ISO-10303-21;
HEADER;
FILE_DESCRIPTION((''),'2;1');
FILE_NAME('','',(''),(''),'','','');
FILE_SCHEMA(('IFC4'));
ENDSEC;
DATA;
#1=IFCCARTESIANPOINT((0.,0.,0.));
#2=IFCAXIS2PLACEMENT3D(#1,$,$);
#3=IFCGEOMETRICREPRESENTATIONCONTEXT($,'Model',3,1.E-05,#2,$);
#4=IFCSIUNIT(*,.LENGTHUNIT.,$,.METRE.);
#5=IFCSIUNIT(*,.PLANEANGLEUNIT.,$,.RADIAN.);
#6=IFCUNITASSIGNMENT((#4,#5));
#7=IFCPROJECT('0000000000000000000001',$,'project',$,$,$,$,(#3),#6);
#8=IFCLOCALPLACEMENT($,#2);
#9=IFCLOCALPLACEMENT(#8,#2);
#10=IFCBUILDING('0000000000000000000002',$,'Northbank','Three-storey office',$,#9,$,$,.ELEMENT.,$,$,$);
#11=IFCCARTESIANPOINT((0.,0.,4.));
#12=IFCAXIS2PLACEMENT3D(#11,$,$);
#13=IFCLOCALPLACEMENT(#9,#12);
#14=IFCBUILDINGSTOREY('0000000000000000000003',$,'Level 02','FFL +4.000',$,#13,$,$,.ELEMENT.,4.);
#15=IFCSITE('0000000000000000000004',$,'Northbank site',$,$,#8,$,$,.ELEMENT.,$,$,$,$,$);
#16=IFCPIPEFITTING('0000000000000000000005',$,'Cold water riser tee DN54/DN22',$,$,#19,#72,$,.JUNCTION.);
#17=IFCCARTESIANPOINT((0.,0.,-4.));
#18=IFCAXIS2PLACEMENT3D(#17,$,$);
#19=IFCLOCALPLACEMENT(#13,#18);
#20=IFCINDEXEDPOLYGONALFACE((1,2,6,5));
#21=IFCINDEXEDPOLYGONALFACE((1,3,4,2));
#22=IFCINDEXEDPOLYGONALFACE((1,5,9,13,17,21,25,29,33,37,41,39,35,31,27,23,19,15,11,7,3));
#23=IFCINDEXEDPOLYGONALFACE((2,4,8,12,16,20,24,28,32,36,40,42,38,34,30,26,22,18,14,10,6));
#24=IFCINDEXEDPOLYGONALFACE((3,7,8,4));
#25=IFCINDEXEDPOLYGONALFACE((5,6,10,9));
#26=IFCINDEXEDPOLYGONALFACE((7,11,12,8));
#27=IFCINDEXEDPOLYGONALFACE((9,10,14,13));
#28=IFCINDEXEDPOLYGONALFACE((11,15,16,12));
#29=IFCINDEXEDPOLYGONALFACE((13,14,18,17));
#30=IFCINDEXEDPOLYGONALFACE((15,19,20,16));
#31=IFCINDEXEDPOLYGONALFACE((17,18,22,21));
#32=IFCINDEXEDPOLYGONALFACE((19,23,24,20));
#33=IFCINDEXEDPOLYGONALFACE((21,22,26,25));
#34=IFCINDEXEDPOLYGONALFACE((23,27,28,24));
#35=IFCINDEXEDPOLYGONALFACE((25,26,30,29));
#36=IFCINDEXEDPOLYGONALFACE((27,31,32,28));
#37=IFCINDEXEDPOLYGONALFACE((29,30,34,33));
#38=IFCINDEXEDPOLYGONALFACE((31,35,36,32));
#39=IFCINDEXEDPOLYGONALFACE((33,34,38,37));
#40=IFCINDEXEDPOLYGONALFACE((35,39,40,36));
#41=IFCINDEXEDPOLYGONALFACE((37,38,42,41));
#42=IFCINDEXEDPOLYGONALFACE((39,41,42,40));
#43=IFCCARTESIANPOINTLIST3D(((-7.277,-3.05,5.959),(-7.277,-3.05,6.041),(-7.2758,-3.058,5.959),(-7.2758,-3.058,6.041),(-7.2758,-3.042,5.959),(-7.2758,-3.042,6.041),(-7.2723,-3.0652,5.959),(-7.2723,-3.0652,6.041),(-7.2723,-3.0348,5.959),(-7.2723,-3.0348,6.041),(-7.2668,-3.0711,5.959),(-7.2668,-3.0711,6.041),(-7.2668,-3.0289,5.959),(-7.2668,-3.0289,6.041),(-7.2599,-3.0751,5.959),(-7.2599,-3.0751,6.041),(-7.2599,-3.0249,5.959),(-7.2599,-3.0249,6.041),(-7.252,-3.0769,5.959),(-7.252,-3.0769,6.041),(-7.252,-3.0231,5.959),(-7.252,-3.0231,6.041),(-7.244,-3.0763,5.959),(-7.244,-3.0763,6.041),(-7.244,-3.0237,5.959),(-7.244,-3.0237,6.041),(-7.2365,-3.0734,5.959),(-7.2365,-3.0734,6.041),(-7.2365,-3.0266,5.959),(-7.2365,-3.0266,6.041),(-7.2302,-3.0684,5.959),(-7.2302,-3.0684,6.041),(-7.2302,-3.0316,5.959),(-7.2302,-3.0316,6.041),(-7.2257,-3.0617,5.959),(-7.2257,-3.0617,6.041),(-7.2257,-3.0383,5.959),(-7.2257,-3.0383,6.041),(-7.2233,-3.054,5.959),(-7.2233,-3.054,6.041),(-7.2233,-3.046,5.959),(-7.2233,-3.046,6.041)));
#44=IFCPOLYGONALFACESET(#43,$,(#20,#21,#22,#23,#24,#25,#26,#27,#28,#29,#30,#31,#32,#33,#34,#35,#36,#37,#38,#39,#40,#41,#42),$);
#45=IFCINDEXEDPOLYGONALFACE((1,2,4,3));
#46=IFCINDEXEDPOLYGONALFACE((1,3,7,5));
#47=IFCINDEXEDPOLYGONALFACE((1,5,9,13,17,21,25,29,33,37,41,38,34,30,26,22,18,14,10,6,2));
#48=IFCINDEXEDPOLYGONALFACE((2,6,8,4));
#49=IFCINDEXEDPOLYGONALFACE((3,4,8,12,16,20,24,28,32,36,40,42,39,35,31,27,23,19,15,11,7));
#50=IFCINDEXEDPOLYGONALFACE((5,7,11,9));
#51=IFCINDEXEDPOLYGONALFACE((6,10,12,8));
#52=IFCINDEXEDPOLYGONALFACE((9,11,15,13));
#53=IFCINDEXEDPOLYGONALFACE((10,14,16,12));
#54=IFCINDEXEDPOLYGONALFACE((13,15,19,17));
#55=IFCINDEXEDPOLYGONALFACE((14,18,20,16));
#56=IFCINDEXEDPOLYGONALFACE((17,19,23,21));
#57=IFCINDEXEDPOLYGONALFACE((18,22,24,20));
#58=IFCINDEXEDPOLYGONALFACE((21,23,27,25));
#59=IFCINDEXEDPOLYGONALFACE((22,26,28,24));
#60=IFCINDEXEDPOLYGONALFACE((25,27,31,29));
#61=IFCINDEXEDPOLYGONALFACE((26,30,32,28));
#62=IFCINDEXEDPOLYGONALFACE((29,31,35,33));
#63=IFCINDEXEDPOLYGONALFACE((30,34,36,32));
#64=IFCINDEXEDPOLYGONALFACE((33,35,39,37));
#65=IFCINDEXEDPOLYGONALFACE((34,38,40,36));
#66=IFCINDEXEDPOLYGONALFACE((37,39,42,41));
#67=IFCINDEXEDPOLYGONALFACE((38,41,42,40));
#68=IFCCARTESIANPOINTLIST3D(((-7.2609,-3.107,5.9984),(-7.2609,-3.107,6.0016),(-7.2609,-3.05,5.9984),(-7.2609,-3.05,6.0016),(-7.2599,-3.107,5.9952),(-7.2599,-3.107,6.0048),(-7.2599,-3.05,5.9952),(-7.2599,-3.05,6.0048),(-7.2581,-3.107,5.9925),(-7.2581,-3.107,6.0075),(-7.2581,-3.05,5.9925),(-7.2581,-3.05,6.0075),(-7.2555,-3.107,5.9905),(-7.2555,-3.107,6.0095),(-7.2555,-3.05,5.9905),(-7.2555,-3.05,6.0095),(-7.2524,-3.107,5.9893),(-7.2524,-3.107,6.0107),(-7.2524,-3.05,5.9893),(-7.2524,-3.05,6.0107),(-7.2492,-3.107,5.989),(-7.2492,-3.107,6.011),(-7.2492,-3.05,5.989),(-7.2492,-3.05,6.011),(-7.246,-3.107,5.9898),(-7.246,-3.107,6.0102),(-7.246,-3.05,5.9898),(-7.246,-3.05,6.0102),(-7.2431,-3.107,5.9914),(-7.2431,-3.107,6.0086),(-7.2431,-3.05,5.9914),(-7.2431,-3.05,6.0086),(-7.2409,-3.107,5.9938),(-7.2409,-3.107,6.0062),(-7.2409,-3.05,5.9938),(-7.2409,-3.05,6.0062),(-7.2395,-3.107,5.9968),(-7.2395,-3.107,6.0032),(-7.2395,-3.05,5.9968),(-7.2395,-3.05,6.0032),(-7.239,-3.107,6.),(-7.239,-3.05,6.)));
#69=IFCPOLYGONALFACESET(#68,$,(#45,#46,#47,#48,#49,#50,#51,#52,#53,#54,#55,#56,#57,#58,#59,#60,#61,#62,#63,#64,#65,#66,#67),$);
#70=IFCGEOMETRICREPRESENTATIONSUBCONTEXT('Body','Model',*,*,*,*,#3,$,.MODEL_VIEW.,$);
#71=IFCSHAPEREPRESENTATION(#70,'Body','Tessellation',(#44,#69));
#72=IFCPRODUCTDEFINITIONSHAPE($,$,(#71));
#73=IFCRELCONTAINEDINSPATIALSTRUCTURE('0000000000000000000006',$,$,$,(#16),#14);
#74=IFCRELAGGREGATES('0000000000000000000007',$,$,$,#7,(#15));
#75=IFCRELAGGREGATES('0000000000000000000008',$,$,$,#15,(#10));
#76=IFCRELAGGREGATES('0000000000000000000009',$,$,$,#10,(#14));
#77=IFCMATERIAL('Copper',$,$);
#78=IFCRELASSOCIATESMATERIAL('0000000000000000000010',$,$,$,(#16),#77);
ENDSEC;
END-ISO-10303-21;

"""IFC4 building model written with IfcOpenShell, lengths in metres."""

from ifc_helpers import new_model, si_unit, frame, origin, place, context, subcontext, project, spatial, circle, extrude, material, element, save


model = new_model("IFC4")

# Units and contexts
model_context = context("Model", 3, precision=1e-05, world=origin())
body_context = subcontext(model_context, "Body", "Model", "MODEL_VIEW")
ifc_project = project(units=[si_unit("LENGTHUNIT", "METRE"), si_unit("PLANEANGLEUNIT", "RADIAN")], contexts=[model_context])

# Site, building, storey
site_placement = place(None, origin())
site = spatial("IfcSite", under=ifc_project, at=site_placement, Name="Northbank site", CompositionType="ELEMENT")
building_placement = place(site_placement, origin())
building = spatial("IfcBuilding", under=site, at=building_placement, Name="Northbank", Description="Three-storey office", CompositionType="ELEMENT")
storey_placement = place(building_placement, frame((0.0, 0.0, 4.0)))
storey = spatial("IfcBuildingStorey", under=building, at=storey_placement, Name="Level 02", Description="FFL +4.000", CompositionType="ELEMENT", Elevation=4.0)

# Pipe fitting
ifc_material_1 = material(Name="Copper")
pipe_fitting_placement = place(storey_placement, frame((0.0, 0.0, -4.0)))
element("IfcPipeFitting", 1, at=pipe_fitting_placement, inside=storey, material=ifc_material_1, Name="Cold water riser tee DN54/DN22", PredefinedType="JUNCTION", context=body_context, shape_type="SweptSolid", body=[
    extrude(circle(Radius=0.027), frame((-7.25, -3.05, 5.959), z_axis=(0.0, 0.0, 1.0), x_axis=(-1.0, 0.0, 0.0)), (0.0, 0.0, 1.0), 0.082),
    extrude(circle(Radius=0.011), frame((-7.25, -3.05, 6.0), z_axis=(0.0, -1.0, 0.0), x_axis=(1.0, 0.0, 0.0)), (0.0, 0.0, 1.0), 0.057),
])

save(model, "model.ifc")
